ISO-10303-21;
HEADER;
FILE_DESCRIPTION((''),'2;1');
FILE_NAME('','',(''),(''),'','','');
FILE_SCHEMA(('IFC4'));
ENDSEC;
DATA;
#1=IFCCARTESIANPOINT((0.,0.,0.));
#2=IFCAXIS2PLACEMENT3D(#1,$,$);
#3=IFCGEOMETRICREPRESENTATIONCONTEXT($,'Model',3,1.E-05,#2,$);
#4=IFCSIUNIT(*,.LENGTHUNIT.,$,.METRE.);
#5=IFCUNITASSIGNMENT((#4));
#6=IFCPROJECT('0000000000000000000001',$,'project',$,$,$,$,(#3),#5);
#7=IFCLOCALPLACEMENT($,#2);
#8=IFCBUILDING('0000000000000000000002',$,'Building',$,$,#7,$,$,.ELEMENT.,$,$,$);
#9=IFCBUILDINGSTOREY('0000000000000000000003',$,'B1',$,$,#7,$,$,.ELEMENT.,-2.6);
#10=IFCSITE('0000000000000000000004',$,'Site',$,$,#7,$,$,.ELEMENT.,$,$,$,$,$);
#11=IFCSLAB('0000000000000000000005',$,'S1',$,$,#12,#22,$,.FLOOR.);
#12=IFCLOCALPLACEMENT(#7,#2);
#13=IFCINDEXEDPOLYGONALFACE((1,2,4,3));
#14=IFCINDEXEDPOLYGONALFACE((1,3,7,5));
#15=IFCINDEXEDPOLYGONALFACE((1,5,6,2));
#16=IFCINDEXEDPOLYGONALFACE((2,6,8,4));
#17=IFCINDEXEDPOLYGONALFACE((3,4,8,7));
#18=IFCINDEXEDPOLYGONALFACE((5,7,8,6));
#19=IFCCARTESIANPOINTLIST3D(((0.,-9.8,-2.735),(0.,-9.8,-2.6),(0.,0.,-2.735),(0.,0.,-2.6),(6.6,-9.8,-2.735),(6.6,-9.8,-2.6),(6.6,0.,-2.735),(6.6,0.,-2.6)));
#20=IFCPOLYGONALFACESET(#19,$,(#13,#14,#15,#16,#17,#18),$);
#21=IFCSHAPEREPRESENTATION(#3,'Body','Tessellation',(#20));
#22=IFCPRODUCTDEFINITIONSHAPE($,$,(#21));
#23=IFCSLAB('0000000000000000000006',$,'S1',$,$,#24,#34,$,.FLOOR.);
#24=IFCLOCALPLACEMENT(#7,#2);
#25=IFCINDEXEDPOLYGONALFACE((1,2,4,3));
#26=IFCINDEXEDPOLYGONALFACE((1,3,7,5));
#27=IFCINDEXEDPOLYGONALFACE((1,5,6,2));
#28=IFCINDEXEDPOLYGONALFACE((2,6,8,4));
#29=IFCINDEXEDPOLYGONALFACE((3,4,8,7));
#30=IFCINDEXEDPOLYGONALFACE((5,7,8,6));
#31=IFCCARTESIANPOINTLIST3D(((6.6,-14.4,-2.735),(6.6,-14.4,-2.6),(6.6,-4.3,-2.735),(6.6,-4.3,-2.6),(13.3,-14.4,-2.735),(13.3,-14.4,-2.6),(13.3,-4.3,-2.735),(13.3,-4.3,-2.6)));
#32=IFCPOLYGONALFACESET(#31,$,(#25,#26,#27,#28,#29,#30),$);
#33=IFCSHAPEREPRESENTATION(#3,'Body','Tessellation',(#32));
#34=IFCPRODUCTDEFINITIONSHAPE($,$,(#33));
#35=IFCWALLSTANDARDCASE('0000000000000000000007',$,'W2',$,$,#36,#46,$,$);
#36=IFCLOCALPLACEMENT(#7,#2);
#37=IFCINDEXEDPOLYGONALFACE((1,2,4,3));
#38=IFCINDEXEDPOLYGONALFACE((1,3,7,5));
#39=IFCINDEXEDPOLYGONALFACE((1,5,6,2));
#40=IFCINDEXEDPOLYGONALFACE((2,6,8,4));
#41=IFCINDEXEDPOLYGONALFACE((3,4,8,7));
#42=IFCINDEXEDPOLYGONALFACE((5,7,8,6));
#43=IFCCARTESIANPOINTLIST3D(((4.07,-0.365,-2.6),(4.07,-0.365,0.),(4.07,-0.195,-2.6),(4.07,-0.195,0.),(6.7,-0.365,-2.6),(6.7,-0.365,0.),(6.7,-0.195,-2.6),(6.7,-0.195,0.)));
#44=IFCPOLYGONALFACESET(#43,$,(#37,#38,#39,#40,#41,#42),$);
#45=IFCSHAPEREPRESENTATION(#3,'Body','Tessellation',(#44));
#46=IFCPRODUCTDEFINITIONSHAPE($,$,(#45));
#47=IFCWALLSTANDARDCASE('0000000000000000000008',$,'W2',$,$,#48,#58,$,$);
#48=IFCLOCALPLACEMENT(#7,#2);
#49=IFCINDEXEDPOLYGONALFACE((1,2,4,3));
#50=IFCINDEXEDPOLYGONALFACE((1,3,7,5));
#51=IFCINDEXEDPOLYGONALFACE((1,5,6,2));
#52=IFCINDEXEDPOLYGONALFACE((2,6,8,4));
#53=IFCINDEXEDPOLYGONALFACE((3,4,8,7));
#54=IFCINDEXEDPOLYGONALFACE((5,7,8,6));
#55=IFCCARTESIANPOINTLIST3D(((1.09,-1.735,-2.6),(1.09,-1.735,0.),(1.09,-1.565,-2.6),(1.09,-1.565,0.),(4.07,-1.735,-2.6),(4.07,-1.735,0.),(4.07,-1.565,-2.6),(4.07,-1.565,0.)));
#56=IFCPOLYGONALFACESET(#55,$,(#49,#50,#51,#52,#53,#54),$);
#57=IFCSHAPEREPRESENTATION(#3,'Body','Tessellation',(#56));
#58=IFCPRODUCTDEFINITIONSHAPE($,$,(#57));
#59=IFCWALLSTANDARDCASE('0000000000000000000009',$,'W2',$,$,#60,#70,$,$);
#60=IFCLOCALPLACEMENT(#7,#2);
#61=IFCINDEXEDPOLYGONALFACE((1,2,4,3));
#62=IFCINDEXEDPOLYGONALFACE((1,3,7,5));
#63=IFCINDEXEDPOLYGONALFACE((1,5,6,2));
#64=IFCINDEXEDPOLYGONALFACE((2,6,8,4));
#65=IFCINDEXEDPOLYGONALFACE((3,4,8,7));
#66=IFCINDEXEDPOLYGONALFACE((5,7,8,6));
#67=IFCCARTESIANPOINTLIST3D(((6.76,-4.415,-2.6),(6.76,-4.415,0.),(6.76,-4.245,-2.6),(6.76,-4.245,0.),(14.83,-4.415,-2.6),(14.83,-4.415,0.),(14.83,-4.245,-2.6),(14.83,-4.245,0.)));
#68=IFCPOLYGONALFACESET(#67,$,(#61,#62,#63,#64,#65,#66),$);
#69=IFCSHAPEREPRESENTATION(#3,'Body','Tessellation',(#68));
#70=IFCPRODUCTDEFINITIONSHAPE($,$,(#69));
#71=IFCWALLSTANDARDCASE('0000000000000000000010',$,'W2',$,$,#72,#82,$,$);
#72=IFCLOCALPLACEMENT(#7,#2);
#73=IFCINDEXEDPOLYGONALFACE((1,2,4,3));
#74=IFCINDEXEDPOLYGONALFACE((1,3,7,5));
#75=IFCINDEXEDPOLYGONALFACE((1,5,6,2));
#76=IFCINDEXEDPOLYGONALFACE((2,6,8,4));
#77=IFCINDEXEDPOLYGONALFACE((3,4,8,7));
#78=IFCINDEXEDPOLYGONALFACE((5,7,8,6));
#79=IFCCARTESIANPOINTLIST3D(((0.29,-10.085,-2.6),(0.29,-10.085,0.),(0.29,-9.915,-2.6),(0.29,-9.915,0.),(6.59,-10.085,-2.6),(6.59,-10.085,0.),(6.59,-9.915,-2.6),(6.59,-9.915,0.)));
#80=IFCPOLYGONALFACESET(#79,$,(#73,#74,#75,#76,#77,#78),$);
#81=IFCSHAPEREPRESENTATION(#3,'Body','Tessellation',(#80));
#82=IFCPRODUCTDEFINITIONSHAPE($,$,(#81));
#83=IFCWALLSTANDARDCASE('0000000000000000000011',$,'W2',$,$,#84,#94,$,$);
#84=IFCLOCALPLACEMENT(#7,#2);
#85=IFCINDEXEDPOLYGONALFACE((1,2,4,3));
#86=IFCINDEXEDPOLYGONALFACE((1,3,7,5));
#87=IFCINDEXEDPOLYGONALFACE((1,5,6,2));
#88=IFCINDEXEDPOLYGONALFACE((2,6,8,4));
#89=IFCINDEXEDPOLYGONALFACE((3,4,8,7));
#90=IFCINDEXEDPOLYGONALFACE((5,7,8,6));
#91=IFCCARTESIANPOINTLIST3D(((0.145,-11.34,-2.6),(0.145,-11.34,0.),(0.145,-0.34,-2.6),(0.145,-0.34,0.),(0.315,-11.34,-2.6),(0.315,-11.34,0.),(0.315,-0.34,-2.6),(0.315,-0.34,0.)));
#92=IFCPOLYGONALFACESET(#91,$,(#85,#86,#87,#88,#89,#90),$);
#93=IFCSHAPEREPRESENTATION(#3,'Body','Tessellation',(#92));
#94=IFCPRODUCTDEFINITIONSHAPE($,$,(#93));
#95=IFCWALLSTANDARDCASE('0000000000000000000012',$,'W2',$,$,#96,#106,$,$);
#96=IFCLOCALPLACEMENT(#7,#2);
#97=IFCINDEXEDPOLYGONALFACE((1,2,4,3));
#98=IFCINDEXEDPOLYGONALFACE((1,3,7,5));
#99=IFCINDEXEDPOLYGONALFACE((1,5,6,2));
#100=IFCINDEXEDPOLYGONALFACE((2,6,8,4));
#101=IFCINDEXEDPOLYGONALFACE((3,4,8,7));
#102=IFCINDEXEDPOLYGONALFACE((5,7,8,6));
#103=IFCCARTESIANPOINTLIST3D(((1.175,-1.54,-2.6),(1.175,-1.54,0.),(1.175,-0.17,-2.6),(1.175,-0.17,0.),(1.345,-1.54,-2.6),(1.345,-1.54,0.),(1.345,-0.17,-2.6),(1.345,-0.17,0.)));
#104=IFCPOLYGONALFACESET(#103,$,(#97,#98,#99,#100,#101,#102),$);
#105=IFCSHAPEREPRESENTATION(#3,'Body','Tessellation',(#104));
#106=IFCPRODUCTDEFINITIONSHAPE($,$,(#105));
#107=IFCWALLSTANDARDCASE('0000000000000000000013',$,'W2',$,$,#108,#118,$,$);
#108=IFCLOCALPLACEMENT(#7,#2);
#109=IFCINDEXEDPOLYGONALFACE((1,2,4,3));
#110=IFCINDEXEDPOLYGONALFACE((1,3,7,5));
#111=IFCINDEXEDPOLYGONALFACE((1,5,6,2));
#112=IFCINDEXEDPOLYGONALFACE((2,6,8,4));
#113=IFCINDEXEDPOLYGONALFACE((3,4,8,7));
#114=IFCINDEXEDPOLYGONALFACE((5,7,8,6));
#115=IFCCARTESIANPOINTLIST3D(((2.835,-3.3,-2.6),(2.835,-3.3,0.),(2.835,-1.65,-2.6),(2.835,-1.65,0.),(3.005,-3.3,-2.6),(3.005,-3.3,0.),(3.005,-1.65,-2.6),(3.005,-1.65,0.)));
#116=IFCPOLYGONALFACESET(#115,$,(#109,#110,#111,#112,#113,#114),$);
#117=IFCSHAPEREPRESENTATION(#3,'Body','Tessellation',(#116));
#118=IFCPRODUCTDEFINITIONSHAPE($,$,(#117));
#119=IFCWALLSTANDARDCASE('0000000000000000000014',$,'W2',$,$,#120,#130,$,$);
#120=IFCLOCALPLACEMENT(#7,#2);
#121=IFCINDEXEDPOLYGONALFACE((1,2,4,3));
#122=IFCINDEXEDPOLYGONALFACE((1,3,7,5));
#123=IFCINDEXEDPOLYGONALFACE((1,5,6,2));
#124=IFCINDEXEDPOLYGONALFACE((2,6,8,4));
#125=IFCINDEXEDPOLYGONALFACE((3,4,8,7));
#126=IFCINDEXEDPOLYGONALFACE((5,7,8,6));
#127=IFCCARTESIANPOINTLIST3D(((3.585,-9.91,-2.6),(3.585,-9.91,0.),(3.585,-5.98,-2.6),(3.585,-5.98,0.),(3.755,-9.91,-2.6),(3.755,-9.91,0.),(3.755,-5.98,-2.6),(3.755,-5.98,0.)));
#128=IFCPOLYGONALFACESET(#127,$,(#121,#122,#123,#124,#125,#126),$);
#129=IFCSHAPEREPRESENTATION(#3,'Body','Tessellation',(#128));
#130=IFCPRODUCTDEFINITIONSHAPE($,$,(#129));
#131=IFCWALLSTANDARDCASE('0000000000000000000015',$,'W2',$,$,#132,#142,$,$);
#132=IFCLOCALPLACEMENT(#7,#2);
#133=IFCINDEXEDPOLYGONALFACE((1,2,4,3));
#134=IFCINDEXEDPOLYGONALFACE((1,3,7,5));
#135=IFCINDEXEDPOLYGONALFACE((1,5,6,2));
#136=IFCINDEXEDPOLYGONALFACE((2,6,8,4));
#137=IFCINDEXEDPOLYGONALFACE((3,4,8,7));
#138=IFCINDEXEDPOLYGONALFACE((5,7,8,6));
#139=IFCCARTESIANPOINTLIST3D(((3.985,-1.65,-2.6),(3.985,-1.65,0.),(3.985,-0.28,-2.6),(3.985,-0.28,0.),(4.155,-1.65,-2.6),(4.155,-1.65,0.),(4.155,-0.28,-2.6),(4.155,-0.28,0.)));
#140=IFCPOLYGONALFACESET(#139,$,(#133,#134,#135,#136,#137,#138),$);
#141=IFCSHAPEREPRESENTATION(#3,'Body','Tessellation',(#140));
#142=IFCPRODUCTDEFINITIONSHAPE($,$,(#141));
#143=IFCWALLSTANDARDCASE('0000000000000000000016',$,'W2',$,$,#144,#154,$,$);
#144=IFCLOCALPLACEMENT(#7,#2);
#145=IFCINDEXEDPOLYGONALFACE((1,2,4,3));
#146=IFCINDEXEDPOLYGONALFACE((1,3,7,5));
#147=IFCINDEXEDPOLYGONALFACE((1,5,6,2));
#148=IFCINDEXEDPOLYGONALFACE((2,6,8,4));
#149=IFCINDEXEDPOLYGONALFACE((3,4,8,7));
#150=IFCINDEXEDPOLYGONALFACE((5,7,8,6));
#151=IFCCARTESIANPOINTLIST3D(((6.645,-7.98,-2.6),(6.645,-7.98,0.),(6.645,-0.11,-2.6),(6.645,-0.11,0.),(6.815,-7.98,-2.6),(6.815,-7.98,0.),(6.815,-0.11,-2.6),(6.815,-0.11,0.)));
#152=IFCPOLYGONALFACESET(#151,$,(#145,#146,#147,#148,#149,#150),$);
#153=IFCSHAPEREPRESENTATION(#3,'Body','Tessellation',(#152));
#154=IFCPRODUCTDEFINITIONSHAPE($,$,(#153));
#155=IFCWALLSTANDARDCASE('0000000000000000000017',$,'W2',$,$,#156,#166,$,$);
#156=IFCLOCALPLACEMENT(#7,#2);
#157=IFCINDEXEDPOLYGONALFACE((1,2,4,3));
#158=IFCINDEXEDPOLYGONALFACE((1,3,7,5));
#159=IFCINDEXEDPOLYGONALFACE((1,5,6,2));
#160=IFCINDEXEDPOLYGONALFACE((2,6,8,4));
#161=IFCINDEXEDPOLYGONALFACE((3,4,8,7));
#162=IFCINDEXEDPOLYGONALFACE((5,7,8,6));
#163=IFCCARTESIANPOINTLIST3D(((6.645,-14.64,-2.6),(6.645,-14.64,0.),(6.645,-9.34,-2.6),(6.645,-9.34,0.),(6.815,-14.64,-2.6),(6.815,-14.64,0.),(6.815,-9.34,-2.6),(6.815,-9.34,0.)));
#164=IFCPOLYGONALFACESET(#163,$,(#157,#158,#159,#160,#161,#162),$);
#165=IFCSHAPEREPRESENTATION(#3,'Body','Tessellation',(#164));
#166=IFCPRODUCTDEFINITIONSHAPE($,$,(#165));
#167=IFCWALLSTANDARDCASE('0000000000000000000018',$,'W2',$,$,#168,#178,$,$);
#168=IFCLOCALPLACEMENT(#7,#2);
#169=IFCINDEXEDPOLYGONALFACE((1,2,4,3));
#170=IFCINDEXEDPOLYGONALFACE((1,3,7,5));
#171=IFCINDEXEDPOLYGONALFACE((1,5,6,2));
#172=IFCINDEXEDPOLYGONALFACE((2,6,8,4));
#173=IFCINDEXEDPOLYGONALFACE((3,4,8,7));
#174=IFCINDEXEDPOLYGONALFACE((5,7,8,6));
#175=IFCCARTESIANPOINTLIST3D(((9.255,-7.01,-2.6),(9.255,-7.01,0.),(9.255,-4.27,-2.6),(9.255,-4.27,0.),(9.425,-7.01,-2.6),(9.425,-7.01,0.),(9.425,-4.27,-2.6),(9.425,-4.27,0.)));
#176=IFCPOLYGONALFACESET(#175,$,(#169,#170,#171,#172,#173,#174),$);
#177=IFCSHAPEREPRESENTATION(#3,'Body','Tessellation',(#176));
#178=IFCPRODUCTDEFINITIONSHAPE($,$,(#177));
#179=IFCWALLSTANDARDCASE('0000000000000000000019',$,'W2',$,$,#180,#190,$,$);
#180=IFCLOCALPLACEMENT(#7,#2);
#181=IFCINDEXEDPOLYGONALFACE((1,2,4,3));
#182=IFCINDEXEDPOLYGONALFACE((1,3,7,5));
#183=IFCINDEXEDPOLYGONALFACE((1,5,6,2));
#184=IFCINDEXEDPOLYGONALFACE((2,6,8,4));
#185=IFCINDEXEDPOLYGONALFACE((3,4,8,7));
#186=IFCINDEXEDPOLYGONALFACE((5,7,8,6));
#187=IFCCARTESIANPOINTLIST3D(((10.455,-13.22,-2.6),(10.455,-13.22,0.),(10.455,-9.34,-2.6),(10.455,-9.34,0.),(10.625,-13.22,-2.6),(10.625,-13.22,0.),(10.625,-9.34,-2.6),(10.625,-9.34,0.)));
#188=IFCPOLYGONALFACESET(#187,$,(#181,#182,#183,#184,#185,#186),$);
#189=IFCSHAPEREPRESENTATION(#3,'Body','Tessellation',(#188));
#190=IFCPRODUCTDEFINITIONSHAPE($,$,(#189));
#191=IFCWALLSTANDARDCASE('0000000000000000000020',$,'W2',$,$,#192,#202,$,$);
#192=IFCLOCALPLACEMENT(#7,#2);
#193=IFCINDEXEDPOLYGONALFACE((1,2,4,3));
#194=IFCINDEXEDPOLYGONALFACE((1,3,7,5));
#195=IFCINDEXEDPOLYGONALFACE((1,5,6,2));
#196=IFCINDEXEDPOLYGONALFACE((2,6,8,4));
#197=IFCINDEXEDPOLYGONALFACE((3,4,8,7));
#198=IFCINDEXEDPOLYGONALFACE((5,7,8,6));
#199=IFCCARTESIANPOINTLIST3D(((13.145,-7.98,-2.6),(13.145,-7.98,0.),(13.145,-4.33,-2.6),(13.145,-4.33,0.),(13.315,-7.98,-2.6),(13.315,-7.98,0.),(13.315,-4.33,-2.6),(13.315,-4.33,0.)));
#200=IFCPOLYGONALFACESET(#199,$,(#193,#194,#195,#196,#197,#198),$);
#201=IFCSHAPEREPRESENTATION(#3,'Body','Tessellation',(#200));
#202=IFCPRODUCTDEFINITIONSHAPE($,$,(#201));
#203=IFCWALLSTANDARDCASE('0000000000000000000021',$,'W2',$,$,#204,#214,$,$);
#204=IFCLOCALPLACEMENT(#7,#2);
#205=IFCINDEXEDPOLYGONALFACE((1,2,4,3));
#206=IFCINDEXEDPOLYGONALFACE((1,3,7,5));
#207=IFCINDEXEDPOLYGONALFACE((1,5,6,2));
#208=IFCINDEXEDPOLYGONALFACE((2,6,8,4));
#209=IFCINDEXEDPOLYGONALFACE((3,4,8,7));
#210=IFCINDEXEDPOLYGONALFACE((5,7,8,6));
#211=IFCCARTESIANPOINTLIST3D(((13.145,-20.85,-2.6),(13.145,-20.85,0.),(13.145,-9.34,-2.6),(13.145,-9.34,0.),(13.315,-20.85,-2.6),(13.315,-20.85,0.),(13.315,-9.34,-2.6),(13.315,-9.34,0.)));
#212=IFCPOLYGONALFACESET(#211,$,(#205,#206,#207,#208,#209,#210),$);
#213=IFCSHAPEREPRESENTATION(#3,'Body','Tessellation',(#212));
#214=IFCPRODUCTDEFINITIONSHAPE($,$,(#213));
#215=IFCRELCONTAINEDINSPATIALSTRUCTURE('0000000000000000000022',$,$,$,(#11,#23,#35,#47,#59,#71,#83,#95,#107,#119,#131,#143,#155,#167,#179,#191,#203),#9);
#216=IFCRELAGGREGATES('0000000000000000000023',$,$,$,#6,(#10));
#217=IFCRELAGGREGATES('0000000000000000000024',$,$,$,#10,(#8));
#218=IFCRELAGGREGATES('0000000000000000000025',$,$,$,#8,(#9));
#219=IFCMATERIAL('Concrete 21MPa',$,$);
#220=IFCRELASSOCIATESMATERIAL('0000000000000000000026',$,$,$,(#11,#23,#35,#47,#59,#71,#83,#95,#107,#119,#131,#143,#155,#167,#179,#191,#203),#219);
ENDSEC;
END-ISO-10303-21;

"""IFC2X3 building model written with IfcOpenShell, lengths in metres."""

from ifc_helpers import new_model, si_unit, frame, origin, origin_2d, place, context, project, spatial, rectangle, extrude, material, element, save


model = new_model("IFC2X3")

# Units and contexts
model_context = context("Model", 3, precision=1e-05, world=origin())
ifc_project = project(units=[si_unit("LENGTHUNIT", "METRE")], contexts=[model_context])

# Site, building, storey
placement = place(None, origin())
site = spatial("IfcSite", under=ifc_project, at=placement, Name="Site", CompositionType="ELEMENT")
building = spatial("IfcBuilding", under=site, at=placement, Name="Building", CompositionType="ELEMENT")
storey = spatial("IfcBuildingStorey", under=building, at=placement, Name="B1", CompositionType="ELEMENT", Elevation=-2.6)

# Slabs
ifc_material_1 = material(Name="Concrete 21MPa")
slab_1_placement = place(None, frame((3.3, -4.9, -2.735)))
element("IfcSlab", 1, at=slab_1_placement, inside=storey, material=ifc_material_1, Name="S1", PredefinedType="FLOOR", context=model_context, shape_type="SweptSolid", body=[
    extrude(rectangle(XDim=6.6, YDim=9.8, at=origin_2d()), origin(), (0.0, 0.0, 1.0), 0.135),
])
slab_2_placement = place(None, frame((9.95, -9.35, -2.735)))
element("IfcSlab", 2, at=slab_2_placement, inside=storey, material=ifc_material_1, Name="S1", PredefinedType="FLOOR", context=model_context, shape_type="SweptSolid", body=[
    extrude(rectangle(XDim=6.7, YDim=10.1, at=origin_2d()), origin(), (0.0, 0.0, 1.0), 0.135),
])

# Walls
wall_1_placement = place(None, frame((5.385, -0.28, -2.6)))
element("IfcWallStandardCase", 3, at=wall_1_placement, inside=storey, material=ifc_material_1, Name="W2", context=model_context, shape_type="SweptSolid", body=[
    extrude(rectangle(XDim=2.63, YDim=0.17, at=origin_2d()), origin(), (0.0, 0.0, 1.0), 2.6),
])
wall_2_placement = place(None, frame((2.58, -1.65, -2.6)))
element("IfcWallStandardCase", 4, at=wall_2_placement, inside=storey, material=ifc_material_1, Name="W2", context=model_context, shape_type="SweptSolid", body=[
    extrude(rectangle(XDim=2.98, YDim=0.17, at=origin_2d()), origin(), (0.0, 0.0, 1.0), 2.6),
])
wall_3_placement = place(None, frame((10.795, -4.33, -2.6)))
element("IfcWallStandardCase", 5, at=wall_3_placement, inside=storey, material=ifc_material_1, Name="W2", context=model_context, shape_type="SweptSolid", body=[
    extrude(rectangle(XDim=8.07, YDim=0.17, at=origin_2d()), origin(), (0.0, 0.0, 1.0), 2.6),
])
wall_4_placement = place(None, frame((3.44, -10.0, -2.6)))
element("IfcWallStandardCase", 6, at=wall_4_placement, inside=storey, material=ifc_material_1, Name="W2", context=model_context, shape_type="SweptSolid", body=[
    extrude(rectangle(XDim=6.3, YDim=0.17, at=origin_2d()), origin(), (0.0, 0.0, 1.0), 2.6),
])
wall_5_placement = place(None, frame((0.23, -5.84, -2.6)))
element("IfcWallStandardCase", 7, at=wall_5_placement, inside=storey, material=ifc_material_1, Name="W2", context=model_context, shape_type="SweptSolid", body=[
    extrude(rectangle(XDim=0.17, YDim=11.0, at=origin_2d()), origin(), (0.0, 0.0, 1.0), 2.6),
])
wall_6_placement = place(None, frame((1.26, -0.855, -2.6)))
element("IfcWallStandardCase", 8, at=wall_6_placement, inside=storey, material=ifc_material_1, Name="W2", context=model_context, shape_type="SweptSolid", body=[
    extrude(rectangle(XDim=0.17, YDim=1.37, at=origin_2d()), origin(), (0.0, 0.0, 1.0), 2.6),
])
wall_7_placement = place(None, frame((2.92, -2.475, -2.6)))
element("IfcWallStandardCase", 9, at=wall_7_placement, inside=storey, material=ifc_material_1, Name="W2", context=model_context, shape_type="SweptSolid", body=[
    extrude(rectangle(XDim=0.17, YDim=1.65, at=origin_2d()), origin(), (0.0, 0.0, 1.0), 2.6),
])
wall_8_placement = place(None, frame((3.67, -7.945, -2.6)))
element("IfcWallStandardCase", 10, at=wall_8_placement, inside=storey, material=ifc_material_1, Name="W2", context=model_context, shape_type="SweptSolid", body=[
    extrude(rectangle(XDim=0.17, YDim=3.93, at=origin_2d()), origin(), (0.0, 0.0, 1.0), 2.6),
])
wall_9_placement = place(None, frame((4.07, -0.965, -2.6)))
element("IfcWallStandardCase", 11, at=wall_9_placement, inside=storey, material=ifc_material_1, Name="W2", context=model_context, shape_type="SweptSolid", body=[
    extrude(rectangle(XDim=0.17, YDim=1.37, at=origin_2d()), origin(), (0.0, 0.0, 1.0), 2.6),
])
wall_10_placement = place(None, frame((6.73, -4.045, -2.6)))
element("IfcWallStandardCase", 12, at=wall_10_placement, inside=storey, material=ifc_material_1, Name="W2", context=model_context, shape_type="SweptSolid", body=[
    extrude(rectangle(XDim=0.17, YDim=7.87, at=origin_2d()), origin(), (0.0, 0.0, 1.0), 2.6),
])
wall_11_placement = place(None, frame((6.73, -11.99, -2.6)))
element("IfcWallStandardCase", 13, at=wall_11_placement, inside=storey, material=ifc_material_1, Name="W2", context=model_context, shape_type="SweptSolid", body=[
    extrude(rectangle(XDim=0.17, YDim=5.3, at=origin_2d()), origin(), (0.0, 0.0, 1.0), 2.6),
])
wall_12_placement = place(None, frame((9.34, -5.64, -2.6)))
element("IfcWallStandardCase", 14, at=wall_12_placement, inside=storey, material=ifc_material_1, Name="W2", context=model_context, shape_type="SweptSolid", body=[
    extrude(rectangle(XDim=0.17, YDim=2.74, at=origin_2d()), origin(), (0.0, 0.0, 1.0), 2.6),
])
wall_13_placement = place(None, frame((10.54, -11.28, -2.6)))
element("IfcWallStandardCase", 15, at=wall_13_placement, inside=storey, material=ifc_material_1, Name="W2", context=model_context, shape_type="SweptSolid", body=[
    extrude(rectangle(XDim=0.17, YDim=3.88, at=origin_2d()), origin(), (0.0, 0.0, 1.0), 2.6),
])
wall_14_placement = place(None, frame((13.23, -6.155, -2.6)))
element("IfcWallStandardCase", 16, at=wall_14_placement, inside=storey, material=ifc_material_1, Name="W2", context=model_context, shape_type="SweptSolid", body=[
    extrude(rectangle(XDim=0.17, YDim=3.65, at=origin_2d()), origin(), (0.0, 0.0, 1.0), 2.6),
])
wall_15_placement = place(None, frame((13.23, -15.095, -2.6)))
element("IfcWallStandardCase", 17, at=wall_15_placement, inside=storey, material=ifc_material_1, Name="W2", context=model_context, shape_type="SweptSolid", body=[
    extrude(rectangle(XDim=0.17, YDim=11.51, at=origin_2d()), origin(), (0.0, 0.0, 1.0), 2.6),
])

save(model, "model.ifc")
